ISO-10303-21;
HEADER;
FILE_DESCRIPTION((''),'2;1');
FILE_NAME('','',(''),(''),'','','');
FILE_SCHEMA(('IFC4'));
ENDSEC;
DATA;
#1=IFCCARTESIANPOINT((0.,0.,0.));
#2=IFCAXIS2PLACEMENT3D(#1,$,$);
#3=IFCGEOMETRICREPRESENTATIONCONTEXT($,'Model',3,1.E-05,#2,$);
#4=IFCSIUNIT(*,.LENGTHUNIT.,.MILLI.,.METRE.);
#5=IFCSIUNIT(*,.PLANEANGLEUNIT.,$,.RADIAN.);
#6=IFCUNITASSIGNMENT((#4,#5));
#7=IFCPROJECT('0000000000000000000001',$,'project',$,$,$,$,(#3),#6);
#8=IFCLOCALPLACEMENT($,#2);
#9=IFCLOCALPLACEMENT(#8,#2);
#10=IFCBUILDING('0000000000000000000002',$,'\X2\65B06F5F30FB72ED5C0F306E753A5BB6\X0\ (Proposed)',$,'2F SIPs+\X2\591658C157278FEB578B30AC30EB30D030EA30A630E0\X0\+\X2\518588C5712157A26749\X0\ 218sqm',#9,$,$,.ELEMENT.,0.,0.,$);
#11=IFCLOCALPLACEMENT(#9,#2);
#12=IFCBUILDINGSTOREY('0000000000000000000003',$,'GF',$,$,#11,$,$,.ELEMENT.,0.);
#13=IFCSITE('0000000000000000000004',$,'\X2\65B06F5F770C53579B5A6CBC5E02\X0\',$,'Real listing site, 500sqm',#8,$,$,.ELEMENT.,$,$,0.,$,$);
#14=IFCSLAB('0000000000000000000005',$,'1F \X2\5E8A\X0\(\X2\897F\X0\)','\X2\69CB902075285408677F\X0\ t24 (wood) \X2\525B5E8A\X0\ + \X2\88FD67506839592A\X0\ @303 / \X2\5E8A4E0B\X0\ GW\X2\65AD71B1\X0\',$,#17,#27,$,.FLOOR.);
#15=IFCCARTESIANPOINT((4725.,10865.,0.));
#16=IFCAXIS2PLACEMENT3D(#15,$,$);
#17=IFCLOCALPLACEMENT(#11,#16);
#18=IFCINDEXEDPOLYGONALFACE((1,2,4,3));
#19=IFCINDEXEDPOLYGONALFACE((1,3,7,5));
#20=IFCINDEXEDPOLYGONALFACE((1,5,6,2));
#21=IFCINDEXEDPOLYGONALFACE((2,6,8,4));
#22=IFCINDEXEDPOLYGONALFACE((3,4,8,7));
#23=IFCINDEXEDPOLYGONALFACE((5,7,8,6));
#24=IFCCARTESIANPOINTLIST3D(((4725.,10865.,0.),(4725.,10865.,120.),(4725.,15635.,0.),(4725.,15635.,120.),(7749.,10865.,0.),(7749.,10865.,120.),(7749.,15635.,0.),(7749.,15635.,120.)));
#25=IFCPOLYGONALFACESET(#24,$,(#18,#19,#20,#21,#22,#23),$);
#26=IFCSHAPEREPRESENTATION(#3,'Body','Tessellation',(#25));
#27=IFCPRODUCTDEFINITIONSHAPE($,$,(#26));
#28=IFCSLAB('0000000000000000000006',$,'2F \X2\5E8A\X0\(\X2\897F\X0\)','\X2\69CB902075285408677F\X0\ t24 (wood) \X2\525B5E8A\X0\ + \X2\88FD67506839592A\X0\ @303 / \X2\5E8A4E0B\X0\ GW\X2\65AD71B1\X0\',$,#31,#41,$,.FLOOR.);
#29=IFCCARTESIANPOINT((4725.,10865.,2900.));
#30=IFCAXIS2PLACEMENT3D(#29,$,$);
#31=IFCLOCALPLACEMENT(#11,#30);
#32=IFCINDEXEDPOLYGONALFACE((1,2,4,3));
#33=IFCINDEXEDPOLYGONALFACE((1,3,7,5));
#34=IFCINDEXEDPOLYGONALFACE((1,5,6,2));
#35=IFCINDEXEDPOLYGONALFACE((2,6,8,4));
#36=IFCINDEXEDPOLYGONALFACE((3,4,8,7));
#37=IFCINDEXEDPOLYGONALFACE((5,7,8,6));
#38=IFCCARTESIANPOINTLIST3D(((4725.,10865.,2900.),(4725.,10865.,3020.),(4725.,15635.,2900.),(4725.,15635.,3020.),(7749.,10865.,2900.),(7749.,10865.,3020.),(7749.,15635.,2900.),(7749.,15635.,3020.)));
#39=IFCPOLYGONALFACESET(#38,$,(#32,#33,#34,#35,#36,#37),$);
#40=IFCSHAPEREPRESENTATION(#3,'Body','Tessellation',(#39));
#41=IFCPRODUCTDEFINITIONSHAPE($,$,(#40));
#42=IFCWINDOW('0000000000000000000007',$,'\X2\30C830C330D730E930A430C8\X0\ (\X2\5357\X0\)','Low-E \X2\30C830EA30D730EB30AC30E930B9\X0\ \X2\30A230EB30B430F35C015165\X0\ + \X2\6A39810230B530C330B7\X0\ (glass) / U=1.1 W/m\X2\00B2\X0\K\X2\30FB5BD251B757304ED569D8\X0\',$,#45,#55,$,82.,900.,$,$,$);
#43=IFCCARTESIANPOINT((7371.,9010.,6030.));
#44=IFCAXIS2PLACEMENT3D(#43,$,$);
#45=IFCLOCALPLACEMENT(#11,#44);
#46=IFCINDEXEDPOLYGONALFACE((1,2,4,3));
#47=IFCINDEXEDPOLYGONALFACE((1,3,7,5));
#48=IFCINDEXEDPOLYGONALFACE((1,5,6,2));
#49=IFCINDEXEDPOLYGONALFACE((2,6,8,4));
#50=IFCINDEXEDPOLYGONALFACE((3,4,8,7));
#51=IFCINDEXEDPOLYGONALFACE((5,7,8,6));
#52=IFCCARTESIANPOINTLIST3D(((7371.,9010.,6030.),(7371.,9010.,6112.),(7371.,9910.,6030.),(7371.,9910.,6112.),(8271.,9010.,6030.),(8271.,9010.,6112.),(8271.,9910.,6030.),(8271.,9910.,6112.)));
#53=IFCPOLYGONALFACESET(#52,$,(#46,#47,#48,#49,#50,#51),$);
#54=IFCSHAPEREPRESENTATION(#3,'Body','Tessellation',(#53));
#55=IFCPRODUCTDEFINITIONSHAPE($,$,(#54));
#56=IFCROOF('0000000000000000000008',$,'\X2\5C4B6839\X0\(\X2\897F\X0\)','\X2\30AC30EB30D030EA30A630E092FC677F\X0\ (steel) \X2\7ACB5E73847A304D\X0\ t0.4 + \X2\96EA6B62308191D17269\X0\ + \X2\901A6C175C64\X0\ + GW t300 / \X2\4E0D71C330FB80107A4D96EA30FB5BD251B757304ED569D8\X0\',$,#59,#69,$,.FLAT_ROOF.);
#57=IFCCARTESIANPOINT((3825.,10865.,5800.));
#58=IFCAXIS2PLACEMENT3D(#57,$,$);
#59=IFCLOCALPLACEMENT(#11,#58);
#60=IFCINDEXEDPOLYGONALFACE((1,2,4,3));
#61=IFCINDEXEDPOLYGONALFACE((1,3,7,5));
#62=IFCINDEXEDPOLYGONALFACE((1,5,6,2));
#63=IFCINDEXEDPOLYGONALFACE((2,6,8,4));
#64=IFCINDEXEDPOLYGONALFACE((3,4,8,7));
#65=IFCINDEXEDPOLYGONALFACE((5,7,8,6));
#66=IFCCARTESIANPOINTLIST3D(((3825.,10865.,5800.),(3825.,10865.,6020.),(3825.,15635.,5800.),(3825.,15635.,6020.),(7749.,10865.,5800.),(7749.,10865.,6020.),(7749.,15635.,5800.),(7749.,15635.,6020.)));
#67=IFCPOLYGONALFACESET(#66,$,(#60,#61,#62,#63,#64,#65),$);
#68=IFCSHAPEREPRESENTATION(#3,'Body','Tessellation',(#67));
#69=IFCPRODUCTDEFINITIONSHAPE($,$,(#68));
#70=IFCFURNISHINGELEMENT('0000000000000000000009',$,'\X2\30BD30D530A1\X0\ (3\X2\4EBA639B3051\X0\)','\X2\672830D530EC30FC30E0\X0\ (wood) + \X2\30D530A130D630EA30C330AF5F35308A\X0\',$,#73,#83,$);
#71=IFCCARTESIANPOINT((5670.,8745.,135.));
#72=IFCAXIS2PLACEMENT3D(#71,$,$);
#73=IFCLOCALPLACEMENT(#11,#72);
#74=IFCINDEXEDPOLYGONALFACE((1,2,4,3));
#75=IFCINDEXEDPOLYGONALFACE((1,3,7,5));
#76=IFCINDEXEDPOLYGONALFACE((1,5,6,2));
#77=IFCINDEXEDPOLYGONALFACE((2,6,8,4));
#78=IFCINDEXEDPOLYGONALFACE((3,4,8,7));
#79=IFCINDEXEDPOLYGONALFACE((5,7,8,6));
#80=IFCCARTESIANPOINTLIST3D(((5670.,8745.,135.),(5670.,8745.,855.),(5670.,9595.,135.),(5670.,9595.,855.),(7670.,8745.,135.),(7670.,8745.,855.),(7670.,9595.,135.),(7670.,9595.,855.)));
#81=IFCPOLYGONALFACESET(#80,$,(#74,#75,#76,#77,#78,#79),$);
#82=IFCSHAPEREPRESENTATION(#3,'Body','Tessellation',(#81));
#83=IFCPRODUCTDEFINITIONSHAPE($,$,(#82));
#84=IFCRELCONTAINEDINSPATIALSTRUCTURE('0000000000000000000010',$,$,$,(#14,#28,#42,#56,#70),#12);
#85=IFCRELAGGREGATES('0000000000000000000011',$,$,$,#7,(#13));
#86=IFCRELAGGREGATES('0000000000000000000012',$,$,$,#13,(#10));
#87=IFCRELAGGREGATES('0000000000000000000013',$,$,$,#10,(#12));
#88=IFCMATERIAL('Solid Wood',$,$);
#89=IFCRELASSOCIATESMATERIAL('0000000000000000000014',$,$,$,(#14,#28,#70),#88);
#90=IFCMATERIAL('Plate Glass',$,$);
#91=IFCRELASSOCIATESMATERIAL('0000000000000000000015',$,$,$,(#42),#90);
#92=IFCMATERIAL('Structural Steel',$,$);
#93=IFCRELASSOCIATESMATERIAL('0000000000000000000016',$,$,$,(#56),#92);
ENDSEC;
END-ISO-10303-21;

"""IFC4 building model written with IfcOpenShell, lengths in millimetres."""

from ifc_helpers import new_model, si_unit, frame, frame_2d, origin, place, context, project, spatial, rectangle, extrude, material, element, save


model = new_model("IFC4")

# Units and contexts
model_context = context("Model", 3, precision=1e-05, world=origin())
ifc_project = project(units=[si_unit("LENGTHUNIT", "METRE", prefix="MILLI"), si_unit("PLANEANGLEUNIT", "RADIAN")], contexts=[model_context])

# Site, building, storey
site_placement = place(None, origin())
site = spatial("IfcSite", under=ifc_project, at=site_placement, Name="新潟県南魚沼市", ObjectType="Real listing site, 500sqm", CompositionType="ELEMENT", RefElevation=0.0)
building_placement = place(site_placement, origin())
building = spatial("IfcBuilding", under=site, at=building_placement, Name="新潟・狭小の町家 (Proposed)", ObjectType="2F SIPs+外壁圧迫型ガルバリウム+内装無垢杉 218sqm", CompositionType="ELEMENT", ElevationOfRefHeight=0.0, ElevationOfTerrain=0.0)
storey_placement = place(building_placement, origin())
storey = spatial("IfcBuildingStorey", under=building, at=storey_placement, Name="GF", CompositionType="ELEMENT", Elevation=0.0)

# Shared definitions
ifc_material_1 = material(Name="Solid Wood")

# Slabs
slab_1_placement = place(storey_placement, frame((4725.0, 10865.0, 0.0)))
element("IfcSlab", 1, at=slab_1_placement, inside=storey, material=ifc_material_1, Name="1F 床(西)", Description="構造用合板 t24 (wood) 剛床 + 製材根太 @303 / 床下 GW断熱", PredefinedType="FLOOR", context=model_context, shape_type="SweptSolid", body=[
    extrude(rectangle(XDim=3024.0, YDim=4770.0, at=frame_2d((1512.0, 2385.0))), frame((4725.0, 10865.0, 0.0)), (0.0, 0.0, 1.0), 120.0),
])
slab_2_placement = place(storey_placement, frame((4725.0, 10865.0, 2900.0)))
element("IfcSlab", 2, at=slab_2_placement, inside=storey, material=ifc_material_1, Name="2F 床(西)", Description="構造用合板 t24 (wood) 剛床 + 製材根太 @303 / 床下 GW断熱", PredefinedType="FLOOR", context=model_context, shape_type="SweptSolid", body=[
    extrude(rectangle(XDim=3024.0, YDim=4770.0, at=frame_2d((1512.0, 2385.0))), frame((4725.0, 10865.0, 2900.0)), (0.0, 0.0, 1.0), 120.0),
])

# Window
ifc_material_2 = material(Name="Plate Glass")
window_placement = place(storey_placement, frame((7371.0, 9010.0, 6030.0)))
element("IfcWindow", 3, at=window_placement, inside=storey, material=ifc_material_2, Name="トップライト (南)", Description="Low-E トリプルガラス アルゴン封入 + 樹脂サッシ (glass) / U=1.1 W/m²K・寒冷地仕様", OverallHeight=82.0, OverallWidth=900.0, context=model_context, shape_type="SweptSolid", body=[
    extrude(rectangle(XDim=900.0, YDim=900.0, at=frame_2d((450.0, 450.0))), frame((7371.0, 9010.0, 6030.0)), (0.0, 0.0, 1.0), 82.0),
])

# Roof
ifc_material_3 = material(Name="Structural Steel")
for number, where, name in (
    (4, (3825.0, 10865.0, 5800.0), "屋根(西)"),
):
    element("IfcRoof", number, at=place(storey_placement, frame(where)), inside=storey, material=ifc_material_3, Name=name, Description="ガルバリウム鋼板 (steel) 立平葺き t0.4 + 雪止め金物 + 通気層 + GW t300 / 不燃・耐積雪・寒冷地仕様", PredefinedType="FLAT_ROOF", context=model_context, shape_type="SweptSolid", body=[
        extrude(rectangle(XDim=3924.0, YDim=4770.0, at=frame_2d((1962.0, 2385.0))), frame((3825.0, 10865.0, 5800.0)), (0.0, 0.0, 1.0), 220.0),
    ])

# Furnishing element
furnishing_placement = place(storey_placement, frame((5670.0, 8745.0, 135.0)))
element("IfcFurnishingElement", 5, at=furnishing_placement, inside=storey, material=ifc_material_1, Name="ソファ (3人掛け)", Description="木フレーム (wood) + ファブリック張り", context=model_context, shape_type="SweptSolid", body=[
    extrude(rectangle(XDim=2000.0, YDim=850.0, at=frame_2d((1000.0, 425.0))), frame((5670.0, 8745.0, 135.0)), (0.0, 0.0, 1.0), 720.0),
])

save(model, "model.ifc")
